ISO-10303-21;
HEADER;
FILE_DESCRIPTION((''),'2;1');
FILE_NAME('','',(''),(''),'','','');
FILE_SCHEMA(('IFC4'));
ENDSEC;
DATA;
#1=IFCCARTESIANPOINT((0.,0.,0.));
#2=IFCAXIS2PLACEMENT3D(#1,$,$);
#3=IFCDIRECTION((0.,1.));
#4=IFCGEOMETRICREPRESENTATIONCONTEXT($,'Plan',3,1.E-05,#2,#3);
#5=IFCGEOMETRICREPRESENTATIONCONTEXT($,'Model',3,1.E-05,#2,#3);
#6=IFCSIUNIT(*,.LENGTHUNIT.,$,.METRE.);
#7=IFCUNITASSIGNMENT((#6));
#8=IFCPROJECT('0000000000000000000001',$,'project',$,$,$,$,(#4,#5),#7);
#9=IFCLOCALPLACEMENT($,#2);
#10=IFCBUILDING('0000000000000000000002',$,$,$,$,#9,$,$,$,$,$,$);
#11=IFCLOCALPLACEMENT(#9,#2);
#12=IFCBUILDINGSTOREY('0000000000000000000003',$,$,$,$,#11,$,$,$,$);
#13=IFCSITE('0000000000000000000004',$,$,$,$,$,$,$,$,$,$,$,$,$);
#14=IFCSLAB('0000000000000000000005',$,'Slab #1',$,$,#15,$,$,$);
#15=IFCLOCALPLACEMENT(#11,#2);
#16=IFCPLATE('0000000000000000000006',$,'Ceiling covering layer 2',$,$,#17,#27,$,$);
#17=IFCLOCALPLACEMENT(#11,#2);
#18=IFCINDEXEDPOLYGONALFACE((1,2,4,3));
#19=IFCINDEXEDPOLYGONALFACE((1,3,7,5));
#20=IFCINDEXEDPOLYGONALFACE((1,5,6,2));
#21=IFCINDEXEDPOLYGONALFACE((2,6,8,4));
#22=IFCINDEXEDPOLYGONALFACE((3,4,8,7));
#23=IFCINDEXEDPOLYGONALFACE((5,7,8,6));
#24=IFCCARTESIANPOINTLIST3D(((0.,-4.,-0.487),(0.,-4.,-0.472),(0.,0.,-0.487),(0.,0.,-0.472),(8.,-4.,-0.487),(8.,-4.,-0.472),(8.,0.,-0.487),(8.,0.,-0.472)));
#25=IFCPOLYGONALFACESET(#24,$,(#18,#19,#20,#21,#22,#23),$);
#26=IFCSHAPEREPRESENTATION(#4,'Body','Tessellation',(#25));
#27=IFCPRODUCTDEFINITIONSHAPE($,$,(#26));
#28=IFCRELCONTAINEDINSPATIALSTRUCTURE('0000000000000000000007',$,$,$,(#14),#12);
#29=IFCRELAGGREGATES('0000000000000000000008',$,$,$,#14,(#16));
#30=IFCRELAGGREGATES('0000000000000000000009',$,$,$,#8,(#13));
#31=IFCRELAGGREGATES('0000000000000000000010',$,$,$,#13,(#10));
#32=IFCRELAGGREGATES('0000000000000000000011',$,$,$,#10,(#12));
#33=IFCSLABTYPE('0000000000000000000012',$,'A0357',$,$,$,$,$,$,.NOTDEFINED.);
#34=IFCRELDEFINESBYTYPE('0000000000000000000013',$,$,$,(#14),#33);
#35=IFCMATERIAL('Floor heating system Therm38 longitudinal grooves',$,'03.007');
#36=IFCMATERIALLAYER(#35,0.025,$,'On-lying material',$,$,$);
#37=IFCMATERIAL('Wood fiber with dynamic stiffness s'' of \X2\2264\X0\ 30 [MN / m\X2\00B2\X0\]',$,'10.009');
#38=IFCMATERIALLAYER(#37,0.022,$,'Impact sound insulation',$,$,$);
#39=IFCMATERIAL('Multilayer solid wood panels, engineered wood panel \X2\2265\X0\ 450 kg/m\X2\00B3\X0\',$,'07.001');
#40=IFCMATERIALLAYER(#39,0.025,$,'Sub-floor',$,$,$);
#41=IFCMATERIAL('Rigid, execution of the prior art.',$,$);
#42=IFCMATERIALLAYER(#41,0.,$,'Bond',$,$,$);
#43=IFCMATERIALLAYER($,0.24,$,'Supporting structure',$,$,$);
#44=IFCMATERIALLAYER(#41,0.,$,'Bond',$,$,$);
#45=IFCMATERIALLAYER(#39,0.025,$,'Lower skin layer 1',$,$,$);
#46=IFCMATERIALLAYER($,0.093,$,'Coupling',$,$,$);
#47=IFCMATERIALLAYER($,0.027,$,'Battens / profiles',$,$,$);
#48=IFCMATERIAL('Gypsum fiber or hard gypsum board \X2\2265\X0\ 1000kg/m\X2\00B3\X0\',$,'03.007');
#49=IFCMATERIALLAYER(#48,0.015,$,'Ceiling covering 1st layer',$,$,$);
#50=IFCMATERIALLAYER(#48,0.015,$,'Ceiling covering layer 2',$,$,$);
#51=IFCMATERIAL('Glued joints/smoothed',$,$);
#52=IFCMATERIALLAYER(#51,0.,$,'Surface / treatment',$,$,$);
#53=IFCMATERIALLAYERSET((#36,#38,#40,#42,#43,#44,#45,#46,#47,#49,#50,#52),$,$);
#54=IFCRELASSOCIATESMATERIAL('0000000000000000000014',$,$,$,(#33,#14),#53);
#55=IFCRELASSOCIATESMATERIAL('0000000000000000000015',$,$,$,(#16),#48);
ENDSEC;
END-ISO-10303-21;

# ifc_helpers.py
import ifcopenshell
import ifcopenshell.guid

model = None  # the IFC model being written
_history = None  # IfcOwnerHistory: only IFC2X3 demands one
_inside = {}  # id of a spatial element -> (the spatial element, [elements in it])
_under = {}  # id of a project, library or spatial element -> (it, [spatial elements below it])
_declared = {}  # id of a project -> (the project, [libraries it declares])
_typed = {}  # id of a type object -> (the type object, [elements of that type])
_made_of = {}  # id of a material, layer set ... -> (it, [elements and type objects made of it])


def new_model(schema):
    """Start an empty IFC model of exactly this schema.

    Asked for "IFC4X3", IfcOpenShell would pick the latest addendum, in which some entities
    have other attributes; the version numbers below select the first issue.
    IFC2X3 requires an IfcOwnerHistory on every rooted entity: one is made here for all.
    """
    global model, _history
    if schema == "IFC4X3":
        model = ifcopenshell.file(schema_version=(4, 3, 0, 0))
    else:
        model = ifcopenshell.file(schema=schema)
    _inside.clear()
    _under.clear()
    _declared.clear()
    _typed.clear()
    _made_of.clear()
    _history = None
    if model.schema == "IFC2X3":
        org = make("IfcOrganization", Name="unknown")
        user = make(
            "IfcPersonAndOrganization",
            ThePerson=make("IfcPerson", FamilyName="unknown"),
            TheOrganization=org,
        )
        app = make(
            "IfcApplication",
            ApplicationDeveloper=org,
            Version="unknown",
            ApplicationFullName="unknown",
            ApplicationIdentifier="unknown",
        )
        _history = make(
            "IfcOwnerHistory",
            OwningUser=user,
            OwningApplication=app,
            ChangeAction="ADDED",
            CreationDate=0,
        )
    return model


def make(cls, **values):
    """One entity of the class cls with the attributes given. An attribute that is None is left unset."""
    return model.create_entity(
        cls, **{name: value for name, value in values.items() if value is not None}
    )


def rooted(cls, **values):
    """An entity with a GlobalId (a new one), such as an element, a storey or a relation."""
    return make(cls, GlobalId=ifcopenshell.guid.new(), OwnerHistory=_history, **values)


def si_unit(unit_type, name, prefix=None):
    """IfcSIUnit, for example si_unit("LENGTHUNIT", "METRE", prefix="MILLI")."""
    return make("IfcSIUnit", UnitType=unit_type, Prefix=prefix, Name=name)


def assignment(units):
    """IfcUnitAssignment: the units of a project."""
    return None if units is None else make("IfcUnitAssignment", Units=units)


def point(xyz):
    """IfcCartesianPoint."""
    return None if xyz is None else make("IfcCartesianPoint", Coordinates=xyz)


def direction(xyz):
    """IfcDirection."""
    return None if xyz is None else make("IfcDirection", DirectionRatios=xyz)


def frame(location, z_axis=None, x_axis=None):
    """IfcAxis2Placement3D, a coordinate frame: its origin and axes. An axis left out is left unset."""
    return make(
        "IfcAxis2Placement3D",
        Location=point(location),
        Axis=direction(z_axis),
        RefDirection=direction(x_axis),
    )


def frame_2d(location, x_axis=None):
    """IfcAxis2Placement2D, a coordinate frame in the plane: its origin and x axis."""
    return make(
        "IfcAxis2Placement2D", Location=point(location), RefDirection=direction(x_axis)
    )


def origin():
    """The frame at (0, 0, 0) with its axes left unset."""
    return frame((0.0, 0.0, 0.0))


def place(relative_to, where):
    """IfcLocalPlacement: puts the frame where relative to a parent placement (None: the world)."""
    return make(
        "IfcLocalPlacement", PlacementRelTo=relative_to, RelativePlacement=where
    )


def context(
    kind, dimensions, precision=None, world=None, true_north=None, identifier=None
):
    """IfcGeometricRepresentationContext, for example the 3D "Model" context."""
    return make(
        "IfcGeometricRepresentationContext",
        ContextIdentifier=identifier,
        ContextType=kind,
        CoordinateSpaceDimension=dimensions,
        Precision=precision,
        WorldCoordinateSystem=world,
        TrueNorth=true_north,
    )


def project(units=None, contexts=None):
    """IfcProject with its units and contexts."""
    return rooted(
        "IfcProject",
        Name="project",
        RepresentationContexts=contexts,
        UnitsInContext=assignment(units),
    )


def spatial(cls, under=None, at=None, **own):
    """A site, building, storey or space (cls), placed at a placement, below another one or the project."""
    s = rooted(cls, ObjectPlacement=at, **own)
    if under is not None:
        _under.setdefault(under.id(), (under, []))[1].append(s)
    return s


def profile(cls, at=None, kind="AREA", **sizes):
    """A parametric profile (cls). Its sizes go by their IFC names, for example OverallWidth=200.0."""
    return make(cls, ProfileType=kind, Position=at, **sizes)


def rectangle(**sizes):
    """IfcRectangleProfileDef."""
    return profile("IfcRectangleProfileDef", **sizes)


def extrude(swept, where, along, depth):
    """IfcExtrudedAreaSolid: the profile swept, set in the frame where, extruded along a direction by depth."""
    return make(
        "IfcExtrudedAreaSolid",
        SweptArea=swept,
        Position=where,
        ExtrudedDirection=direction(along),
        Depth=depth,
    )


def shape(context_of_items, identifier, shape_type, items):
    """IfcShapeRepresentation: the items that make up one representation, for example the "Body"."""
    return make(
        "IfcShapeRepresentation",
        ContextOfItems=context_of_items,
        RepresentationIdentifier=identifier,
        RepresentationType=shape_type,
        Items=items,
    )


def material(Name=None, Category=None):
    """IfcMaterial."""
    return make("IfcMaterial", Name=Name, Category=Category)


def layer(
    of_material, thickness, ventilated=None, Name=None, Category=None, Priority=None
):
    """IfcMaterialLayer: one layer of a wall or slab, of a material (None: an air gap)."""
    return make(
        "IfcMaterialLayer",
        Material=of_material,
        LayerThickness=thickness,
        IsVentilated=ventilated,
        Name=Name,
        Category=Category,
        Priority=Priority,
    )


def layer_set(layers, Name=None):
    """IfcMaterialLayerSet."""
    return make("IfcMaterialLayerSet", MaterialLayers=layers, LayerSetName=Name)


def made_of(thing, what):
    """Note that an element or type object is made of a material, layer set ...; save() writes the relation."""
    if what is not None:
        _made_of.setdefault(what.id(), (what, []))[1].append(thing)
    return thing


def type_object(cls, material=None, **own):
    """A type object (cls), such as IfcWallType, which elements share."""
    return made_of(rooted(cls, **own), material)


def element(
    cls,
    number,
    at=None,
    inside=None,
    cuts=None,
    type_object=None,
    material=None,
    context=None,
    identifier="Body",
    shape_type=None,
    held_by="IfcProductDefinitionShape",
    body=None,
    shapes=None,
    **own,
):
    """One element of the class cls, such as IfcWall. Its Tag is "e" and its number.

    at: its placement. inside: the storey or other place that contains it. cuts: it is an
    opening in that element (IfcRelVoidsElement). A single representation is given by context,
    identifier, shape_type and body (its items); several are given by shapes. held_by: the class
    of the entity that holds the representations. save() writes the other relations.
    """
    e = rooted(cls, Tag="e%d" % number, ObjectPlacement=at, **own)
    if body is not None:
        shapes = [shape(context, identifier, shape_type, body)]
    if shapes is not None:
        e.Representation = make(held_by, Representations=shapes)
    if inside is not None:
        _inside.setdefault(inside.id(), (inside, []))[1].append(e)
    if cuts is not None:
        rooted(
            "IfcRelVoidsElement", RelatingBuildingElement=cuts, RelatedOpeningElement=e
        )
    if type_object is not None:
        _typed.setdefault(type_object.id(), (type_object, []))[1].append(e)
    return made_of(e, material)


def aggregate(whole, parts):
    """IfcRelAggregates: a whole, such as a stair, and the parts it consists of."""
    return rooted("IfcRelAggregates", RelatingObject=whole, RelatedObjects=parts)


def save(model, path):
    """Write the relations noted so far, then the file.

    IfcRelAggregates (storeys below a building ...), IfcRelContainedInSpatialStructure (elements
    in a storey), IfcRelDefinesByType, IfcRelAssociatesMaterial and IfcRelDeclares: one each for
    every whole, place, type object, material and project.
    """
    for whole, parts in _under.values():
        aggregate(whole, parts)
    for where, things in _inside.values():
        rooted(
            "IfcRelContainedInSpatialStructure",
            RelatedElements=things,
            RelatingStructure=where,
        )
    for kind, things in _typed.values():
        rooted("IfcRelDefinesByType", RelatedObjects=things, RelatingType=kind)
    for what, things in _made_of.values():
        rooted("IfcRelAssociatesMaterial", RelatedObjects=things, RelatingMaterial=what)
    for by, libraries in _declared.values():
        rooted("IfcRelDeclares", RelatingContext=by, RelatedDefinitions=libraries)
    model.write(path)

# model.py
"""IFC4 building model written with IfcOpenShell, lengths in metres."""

from ifc_helpers import new_model, si_unit, direction, frame, frame_2d, origin, place, context, project, spatial, rectangle, extrude, material, layer, layer_set, type_object, element, aggregate, save


model = new_model("IFC4")

# Units and contexts
plan_context = context("Plan", 3, precision=1e-05, world=origin(), true_north=direction((0.0, 1.0)))
model_context = context("Model", 3, precision=1e-05, world=origin(), true_north=direction((0.0, 1.0)))
ifc_project = project(units=[si_unit("LENGTHUNIT", "METRE")], contexts=[plan_context, model_context])

# Site, building, storey
site = spatial("IfcSite", under=ifc_project)
building_placement = place(None, origin())
building = spatial("IfcBuilding", under=site, at=building_placement)
storey_placement = place(building_placement, origin())
storey = spatial("IfcBuildingStorey", under=building, at=storey_placement)

# Slab, plate
ifc_material_1 = material(Name="Floor heating system Therm38 longitudinal grooves", Category="03.007")
ifc_layer_1 = layer(ifc_material_1, 0.025, Name="On-lying material")
ifc_material_2 = material(Name="Wood fiber with dynamic stiffness s' of ≤ 30 [MN / m²]", Category="10.009")
ifc_layer_2 = layer(ifc_material_2, 0.022, Name="Impact sound insulation")
ifc_material_3 = material(Name="Multilayer solid wood panels, engineered wood panel ≥ 450 kg/m³", Category="07.001")
ifc_layer_3 = layer(ifc_material_3, 0.025, Name="Sub-floor")
ifc_material_4 = material(Name="Rigid, execution of the prior art.")
ifc_layer_4 = layer(ifc_material_4, 0.0, Name="Bond")
ifc_layer_5 = layer(None, 0.24, Name="Supporting structure")
ifc_layer_6 = layer(ifc_material_4, 0.0, Name="Bond")
ifc_layer_7 = layer(ifc_material_3, 0.025, Name="Lower skin layer 1")
ifc_layer_8 = layer(None, 0.093, Name="Coupling")
ifc_layer_9 = layer(None, 0.027, Name="Battens / profiles")
ifc_material_5 = material(Name="Gypsum fiber or hard gypsum board ≥ 1000kg/m³", Category="03.007")
ifc_layer_10 = layer(ifc_material_5, 0.015, Name="Ceiling covering 1st layer")
ifc_layer_11 = layer(ifc_material_5, 0.015, Name="Ceiling covering layer 2")
ifc_material_6 = material(Name="Glued joints/smoothed")
ifc_layer_12 = layer(ifc_material_6, 0.0, Name="Surface / treatment")
ifc_layer_set = layer_set([ifc_layer_1, ifc_layer_2, ifc_layer_3, ifc_layer_4, ifc_layer_5, ifc_layer_6, ifc_layer_7, ifc_layer_8, ifc_layer_9, ifc_layer_10, ifc_layer_11, ifc_layer_12])
slab_type = type_object("IfcSlabType", Name="A0357", PredefinedType="NOTDEFINED", material=ifc_layer_set)
slab_placement = place(None, frame((0.0, 0.0, 0.0), z_axis=(0.0, 0.0, -1.0), x_axis=(1.0, 0.0, 0.0)))
slab = element("IfcSlab", 1, at=slab_placement, inside=storey, type_object=slab_type, material=ifc_layer_set, Name="Slab #1")
plate_1_placement = place(slab_placement, origin())
plate_1 = element("IfcPlate", 2, at=plate_1_placement, material=ifc_material_5, Name="Ceiling covering layer 2", context=plan_context, shape_type="SweptSolid", body=[
    extrude(rectangle(XDim=8.0, YDim=4.0, at=frame_2d((4.0, 2.0), x_axis=(1.0, 0.0))), frame((0.0, 0.0, 0.472), z_axis=(0.0, 0.0, 1.0), x_axis=(1.0, 0.0, 0.0)), (0.0, 0.0, 1.0), 0.015),
])
aggregate(slab, [plate_1])

save(model, "model.ifc")
